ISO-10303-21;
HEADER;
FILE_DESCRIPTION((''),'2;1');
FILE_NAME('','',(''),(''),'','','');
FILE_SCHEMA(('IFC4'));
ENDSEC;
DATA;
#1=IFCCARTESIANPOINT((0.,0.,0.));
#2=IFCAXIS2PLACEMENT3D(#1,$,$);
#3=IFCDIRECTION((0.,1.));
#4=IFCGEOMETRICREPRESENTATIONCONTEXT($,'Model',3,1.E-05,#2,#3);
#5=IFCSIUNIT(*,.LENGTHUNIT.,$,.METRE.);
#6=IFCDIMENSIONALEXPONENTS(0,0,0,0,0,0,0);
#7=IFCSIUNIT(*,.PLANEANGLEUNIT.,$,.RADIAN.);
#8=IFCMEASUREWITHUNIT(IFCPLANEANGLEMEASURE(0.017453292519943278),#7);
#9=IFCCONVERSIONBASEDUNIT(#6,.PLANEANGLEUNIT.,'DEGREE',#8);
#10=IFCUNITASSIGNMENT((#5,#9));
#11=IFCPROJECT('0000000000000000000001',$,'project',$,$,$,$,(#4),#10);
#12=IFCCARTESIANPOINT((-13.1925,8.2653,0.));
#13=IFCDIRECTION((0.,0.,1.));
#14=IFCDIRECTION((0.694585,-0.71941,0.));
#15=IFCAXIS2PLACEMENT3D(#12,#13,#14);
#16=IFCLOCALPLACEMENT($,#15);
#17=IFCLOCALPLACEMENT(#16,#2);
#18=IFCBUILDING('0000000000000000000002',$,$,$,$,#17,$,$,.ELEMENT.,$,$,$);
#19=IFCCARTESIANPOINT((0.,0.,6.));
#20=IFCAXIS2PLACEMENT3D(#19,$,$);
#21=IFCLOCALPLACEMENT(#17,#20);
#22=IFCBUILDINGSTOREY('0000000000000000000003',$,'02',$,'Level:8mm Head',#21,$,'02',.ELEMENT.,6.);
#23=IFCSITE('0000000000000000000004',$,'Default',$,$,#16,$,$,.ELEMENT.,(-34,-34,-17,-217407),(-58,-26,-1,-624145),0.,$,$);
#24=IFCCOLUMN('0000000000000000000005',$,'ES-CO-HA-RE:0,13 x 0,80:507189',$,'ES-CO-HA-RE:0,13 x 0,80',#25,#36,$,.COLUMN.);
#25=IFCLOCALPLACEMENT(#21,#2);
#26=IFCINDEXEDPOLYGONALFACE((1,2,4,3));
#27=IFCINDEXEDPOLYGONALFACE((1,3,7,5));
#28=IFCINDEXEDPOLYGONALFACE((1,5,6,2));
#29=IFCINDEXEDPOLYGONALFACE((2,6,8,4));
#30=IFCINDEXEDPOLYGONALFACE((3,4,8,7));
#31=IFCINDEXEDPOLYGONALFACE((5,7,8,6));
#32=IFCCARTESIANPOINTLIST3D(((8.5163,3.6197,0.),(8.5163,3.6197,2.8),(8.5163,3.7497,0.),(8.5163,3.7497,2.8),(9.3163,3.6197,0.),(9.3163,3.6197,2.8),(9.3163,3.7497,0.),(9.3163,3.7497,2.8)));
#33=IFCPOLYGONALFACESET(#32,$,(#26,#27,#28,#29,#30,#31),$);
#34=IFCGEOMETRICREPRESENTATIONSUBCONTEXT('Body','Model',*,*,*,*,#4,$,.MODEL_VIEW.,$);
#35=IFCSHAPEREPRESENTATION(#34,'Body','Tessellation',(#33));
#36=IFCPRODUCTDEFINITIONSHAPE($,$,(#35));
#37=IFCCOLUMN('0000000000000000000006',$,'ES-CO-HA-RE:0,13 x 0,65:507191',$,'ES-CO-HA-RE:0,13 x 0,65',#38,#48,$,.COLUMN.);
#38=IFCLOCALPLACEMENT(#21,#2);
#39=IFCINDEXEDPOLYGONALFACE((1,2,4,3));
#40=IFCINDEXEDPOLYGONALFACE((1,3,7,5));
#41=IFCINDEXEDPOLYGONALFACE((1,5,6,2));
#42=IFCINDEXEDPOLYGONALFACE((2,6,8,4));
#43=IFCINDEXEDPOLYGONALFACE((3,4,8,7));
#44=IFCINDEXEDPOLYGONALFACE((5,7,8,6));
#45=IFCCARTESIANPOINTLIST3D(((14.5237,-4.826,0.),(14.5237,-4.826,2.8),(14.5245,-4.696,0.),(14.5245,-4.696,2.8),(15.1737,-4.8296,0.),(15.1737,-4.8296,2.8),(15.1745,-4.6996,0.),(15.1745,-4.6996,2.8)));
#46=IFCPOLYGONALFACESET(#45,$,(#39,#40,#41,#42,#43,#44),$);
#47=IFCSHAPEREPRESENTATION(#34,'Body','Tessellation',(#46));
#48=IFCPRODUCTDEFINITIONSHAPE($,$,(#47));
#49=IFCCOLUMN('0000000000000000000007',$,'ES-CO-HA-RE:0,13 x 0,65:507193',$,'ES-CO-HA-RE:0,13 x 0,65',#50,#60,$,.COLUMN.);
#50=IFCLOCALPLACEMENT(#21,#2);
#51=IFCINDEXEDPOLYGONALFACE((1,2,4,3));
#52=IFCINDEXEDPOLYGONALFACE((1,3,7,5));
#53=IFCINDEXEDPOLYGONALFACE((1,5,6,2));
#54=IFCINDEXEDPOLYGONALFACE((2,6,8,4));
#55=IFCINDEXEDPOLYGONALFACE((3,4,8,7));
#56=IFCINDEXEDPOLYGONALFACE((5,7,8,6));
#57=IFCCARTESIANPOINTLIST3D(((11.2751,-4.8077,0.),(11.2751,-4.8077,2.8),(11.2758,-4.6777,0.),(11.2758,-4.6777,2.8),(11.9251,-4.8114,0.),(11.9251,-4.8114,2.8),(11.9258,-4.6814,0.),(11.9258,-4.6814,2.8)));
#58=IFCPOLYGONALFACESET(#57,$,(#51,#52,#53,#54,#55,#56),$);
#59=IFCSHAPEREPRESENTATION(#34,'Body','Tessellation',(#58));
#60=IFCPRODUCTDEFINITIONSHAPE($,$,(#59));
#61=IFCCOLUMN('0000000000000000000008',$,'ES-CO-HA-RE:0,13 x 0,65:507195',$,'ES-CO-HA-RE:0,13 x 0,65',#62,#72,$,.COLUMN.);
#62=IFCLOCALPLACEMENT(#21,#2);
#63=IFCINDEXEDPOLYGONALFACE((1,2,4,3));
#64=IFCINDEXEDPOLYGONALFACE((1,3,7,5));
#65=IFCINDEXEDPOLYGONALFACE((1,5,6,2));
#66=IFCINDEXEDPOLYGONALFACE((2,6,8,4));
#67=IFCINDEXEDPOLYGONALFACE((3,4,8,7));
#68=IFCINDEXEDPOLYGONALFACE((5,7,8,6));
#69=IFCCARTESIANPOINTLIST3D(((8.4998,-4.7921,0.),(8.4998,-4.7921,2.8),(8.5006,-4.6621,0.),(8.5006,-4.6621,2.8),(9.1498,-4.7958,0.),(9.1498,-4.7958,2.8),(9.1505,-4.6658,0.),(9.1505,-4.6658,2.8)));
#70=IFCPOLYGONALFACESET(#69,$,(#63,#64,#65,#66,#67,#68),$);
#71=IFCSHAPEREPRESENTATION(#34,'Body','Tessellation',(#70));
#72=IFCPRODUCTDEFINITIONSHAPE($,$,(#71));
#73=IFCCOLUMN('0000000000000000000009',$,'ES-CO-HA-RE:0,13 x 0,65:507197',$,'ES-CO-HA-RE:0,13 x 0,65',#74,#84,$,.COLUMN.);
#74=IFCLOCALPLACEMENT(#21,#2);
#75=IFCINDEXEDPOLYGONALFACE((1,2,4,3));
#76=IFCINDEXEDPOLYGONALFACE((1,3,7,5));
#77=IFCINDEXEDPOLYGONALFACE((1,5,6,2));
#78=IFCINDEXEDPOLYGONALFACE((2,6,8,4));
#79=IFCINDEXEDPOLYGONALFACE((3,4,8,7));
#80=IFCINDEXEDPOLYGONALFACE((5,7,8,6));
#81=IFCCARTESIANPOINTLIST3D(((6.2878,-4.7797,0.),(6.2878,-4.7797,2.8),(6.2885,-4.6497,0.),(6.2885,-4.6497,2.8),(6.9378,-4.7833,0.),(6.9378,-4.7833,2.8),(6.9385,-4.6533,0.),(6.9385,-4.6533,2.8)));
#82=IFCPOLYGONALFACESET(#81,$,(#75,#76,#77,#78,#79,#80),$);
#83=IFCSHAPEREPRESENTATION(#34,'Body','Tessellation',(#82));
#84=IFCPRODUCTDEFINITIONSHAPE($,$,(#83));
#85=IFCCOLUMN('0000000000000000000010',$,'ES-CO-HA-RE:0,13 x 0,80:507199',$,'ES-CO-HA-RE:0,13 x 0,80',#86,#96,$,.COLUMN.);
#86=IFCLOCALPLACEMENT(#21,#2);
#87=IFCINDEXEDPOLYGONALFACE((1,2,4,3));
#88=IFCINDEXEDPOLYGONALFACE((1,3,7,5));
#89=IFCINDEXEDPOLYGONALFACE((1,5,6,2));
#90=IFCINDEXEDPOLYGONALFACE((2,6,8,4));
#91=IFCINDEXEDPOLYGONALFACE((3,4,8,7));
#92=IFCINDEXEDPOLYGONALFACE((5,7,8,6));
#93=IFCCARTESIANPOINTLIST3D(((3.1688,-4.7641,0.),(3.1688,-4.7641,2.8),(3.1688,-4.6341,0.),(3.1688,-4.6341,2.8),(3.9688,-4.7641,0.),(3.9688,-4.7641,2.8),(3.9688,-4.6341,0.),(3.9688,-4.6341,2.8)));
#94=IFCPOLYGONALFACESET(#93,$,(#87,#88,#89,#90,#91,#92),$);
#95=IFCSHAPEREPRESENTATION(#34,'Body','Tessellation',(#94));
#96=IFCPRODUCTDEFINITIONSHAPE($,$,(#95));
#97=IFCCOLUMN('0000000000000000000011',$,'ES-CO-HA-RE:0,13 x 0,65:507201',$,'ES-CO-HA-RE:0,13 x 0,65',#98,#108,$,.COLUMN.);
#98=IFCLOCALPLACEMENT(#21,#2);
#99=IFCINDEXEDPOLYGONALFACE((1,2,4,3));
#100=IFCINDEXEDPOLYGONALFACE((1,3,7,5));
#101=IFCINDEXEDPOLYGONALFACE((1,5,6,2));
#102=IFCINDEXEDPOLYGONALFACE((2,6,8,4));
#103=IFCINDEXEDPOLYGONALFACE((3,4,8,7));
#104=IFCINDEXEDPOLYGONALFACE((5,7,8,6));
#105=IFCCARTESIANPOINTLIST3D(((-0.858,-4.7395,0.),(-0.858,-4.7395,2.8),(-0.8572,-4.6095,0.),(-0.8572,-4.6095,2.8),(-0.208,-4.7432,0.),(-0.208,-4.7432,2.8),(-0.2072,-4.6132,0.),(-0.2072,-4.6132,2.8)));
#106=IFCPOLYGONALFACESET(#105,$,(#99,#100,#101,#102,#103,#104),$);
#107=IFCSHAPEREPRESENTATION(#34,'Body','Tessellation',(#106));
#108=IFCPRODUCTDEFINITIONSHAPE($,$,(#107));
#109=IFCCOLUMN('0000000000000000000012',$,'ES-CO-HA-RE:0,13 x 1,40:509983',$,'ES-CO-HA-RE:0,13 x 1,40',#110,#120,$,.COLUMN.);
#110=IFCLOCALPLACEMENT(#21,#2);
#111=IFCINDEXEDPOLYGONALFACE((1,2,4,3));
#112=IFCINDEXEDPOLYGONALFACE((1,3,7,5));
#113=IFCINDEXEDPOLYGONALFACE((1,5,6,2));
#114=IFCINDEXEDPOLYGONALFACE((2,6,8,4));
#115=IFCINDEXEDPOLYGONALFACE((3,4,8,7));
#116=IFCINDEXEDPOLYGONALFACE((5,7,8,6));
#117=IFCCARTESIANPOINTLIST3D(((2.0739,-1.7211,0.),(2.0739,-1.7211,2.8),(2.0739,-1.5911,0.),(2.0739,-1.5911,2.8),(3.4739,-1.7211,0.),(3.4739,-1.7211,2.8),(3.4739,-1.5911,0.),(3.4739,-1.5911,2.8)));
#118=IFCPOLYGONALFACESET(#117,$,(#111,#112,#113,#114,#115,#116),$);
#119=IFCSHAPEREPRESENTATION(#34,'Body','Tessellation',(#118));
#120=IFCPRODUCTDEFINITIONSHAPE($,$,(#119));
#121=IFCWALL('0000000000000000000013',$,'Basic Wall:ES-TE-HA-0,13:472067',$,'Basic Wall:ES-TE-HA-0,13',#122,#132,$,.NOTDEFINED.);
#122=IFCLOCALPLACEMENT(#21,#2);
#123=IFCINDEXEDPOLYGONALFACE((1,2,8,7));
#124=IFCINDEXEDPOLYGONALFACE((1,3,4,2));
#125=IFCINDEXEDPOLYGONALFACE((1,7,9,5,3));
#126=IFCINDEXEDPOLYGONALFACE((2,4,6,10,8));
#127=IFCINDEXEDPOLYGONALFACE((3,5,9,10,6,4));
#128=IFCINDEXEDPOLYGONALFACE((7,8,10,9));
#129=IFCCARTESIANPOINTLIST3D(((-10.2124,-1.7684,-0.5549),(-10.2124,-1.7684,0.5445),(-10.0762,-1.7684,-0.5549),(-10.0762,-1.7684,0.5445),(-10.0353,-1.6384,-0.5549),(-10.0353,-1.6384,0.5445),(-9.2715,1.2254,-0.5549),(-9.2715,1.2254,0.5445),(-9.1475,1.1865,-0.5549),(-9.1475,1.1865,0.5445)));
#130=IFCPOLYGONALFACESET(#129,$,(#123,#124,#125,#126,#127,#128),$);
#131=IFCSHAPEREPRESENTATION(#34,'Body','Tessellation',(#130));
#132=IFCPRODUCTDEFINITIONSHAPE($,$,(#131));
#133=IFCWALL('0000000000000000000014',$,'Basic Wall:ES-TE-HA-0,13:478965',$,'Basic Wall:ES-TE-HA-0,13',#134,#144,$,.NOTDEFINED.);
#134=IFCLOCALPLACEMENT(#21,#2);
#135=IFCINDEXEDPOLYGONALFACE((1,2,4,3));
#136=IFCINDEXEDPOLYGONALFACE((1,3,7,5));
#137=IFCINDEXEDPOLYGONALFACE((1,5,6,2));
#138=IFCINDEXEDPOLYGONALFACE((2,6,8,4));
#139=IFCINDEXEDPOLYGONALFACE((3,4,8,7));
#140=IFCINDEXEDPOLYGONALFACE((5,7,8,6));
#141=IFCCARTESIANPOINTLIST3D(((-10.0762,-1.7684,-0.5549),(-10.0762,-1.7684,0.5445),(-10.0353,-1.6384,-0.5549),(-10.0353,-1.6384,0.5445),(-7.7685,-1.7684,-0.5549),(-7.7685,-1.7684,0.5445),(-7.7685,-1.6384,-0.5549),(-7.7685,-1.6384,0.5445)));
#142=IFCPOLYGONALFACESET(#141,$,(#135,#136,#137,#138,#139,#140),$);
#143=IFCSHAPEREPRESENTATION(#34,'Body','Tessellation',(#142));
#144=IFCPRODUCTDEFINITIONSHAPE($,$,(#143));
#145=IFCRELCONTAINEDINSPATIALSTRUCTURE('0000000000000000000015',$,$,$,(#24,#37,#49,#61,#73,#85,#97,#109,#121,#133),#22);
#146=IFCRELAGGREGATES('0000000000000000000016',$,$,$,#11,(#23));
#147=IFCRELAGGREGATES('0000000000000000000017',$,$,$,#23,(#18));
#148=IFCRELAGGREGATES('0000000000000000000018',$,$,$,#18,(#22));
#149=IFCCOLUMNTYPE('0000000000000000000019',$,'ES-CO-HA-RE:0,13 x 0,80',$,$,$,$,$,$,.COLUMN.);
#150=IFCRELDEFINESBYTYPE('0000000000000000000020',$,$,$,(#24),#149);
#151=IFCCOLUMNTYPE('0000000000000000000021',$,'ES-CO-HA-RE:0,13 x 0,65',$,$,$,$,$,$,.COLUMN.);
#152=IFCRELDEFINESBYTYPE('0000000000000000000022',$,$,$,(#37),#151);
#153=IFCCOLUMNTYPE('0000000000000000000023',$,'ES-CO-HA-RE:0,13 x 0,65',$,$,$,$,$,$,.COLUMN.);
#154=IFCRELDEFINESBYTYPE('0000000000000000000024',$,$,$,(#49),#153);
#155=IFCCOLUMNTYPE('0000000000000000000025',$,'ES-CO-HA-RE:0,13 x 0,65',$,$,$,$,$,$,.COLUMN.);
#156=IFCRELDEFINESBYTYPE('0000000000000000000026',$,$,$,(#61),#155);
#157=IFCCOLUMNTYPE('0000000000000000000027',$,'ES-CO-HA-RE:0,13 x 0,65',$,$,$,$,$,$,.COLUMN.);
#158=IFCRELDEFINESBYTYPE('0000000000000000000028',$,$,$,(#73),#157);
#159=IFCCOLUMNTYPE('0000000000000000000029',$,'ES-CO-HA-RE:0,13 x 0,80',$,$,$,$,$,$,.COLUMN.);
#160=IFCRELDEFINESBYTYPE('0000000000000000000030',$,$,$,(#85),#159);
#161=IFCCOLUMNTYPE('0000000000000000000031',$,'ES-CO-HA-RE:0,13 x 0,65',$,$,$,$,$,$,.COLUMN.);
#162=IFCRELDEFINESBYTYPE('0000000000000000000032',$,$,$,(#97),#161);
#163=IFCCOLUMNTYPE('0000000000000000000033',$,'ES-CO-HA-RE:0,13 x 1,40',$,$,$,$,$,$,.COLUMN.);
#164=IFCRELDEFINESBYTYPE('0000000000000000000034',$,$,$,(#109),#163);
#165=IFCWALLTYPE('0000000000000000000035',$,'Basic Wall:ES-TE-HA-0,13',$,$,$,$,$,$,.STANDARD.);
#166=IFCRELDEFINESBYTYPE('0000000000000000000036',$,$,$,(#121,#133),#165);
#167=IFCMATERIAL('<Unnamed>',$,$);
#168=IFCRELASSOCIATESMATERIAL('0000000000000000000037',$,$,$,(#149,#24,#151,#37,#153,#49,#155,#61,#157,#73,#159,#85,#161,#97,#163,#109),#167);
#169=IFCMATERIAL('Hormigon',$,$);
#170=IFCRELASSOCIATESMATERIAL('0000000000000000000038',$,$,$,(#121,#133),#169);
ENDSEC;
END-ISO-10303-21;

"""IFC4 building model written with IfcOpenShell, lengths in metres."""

from ifc_helpers import new_model, entity, si_unit, converted_unit, direction, frame, origin, place, context, subcontext, project, spatial, indexed_curve, outline, extrude, source, transform, mapped, material, type_object, type_shapes, element, save


model = new_model("IFC4")

# Units and contexts
model_context = context("Model", 3, precision=1e-05, world=origin(), true_north=direction((0.0, 1.0)))
body_context = subcontext(model_context, "Body", "Model", "MODEL_VIEW")
ifc_project = project(units=[si_unit("LENGTHUNIT", "METRE"), converted_unit("PLANEANGLEUNIT", "DEGREE", entity("IfcPlaneAngleMeasure", 0.017453292519943278), si_unit("PLANEANGLEUNIT", "RADIAN"), dimensions=[0, 0, 0, 0, 0, 0, 0])], contexts=[model_context])

# Site, building, storey
site_placement = place(None, frame((-13.1925, 8.2653, 0.0), z_axis=(0.0, 0.0, 1.0), x_axis=(0.694585, -0.71941, 0.0)))
site = spatial("IfcSite", under=ifc_project, at=site_placement, Name="Default", CompositionType="ELEMENT", RefLatitude=(-34, -34, -17, -217407), RefLongitude=(-58, -26, -1, -624145), RefElevation=0.0)
building_placement = place(site_placement, origin())
building = spatial("IfcBuilding", under=site, at=building_placement, CompositionType="ELEMENT")
storey_placement = place(building_placement, frame((0.0, 0.0, 6.0)))
storey = spatial("IfcBuildingStorey", under=building, at=storey_placement, Name="02", ObjectType="Level:8mm Head", LongName="02", CompositionType="ELEMENT", Elevation=6.0)

# Columns
ifc_material_1 = material(Name="<Unnamed>")
ifc_material_2 = material(Name="Hormigon")
column_type_1 = type_object("IfcColumnType", Name="ES-CO-HA-RE:0,13 x 0,80", PredefinedType="COLUMN", material=ifc_material_1)
shared_shape_1 = source(origin(), body_context, "Body", "SweptSolid", [
    extrude(outline(indexed_curve([(-0.4, -0.065), (0.4, -0.065), (0.4, 0.065), (-0.4, 0.065), (-0.4, -0.065)], self_intersect=False)), frame((8.9163, 3.6847, 6.0), z_axis=(0.0, 0.0, 1.0), x_axis=(-1.0, 0.0, 0.0)), (0.0, 0.0, 1.0), 2.8),
])
type_shapes(column_type_1, [shared_shape_1])
column_1_placement = place(storey_placement, frame((0.0, 0.0, -6.0)))
element("IfcColumn", 1, at=column_1_placement, inside=storey, type_object=column_type_1, material=ifc_material_1, Name="ES-CO-HA-RE:0,13 x 0,80:507189", ObjectType="ES-CO-HA-RE:0,13 x 0,80", PredefinedType="COLUMN", context=body_context, shape_type="MappedRepresentation", body=[
    mapped(shared_shape_1, transform((0.0, 0.0, 0.0), scale=1.0)),
])
column_type_2 = type_object("IfcColumnType", Name="ES-CO-HA-RE:0,13 x 0,65", PredefinedType="COLUMN", material=ifc_material_1)
shared_shape_2 = source(origin(), body_context, "Body", "SweptSolid", [
    extrude(outline(indexed_curve([(-0.325, -0.065), (0.325, -0.065), (0.325, 0.065), (-0.325, 0.065), (-0.325, -0.065)], self_intersect=False)), frame((14.8491, -4.7628, 6.0), z_axis=(0.0, 0.0, 1.0), x_axis=(-0.999984, 0.005619, 0.0)), (0.0, 0.0, 1.0), 2.8),
])
type_shapes(column_type_2, [shared_shape_2])
column_2_placement = place(storey_placement, frame((0.0, 0.0, -6.0)))
element("IfcColumn", 2, at=column_2_placement, inside=storey, type_object=column_type_2, material=ifc_material_1, Name="ES-CO-HA-RE:0,13 x 0,65:507191", ObjectType="ES-CO-HA-RE:0,13 x 0,65", PredefinedType="COLUMN", context=body_context, shape_type="MappedRepresentation", body=[
    mapped(shared_shape_2, transform((0.0, 0.0, 0.0), scale=1.0)),
])
column_type_3 = type_object("IfcColumnType", Name="ES-CO-HA-RE:0,13 x 0,65", PredefinedType="COLUMN", material=ifc_material_1)
shared_shape_3 = source(origin(), body_context, "Body", "SweptSolid", [
    extrude(outline(indexed_curve([(-0.325, -0.065), (0.325, -0.065), (0.325, 0.065), (-0.325, 0.065), (-0.325, -0.065)], self_intersect=False)), frame((11.6005, -4.7445, 6.0), z_axis=(0.0, 0.0, 1.0), x_axis=(-0.999984, 0.005619, 0.0)), (0.0, 0.0, 1.0), 2.8),
])
type_shapes(column_type_3, [shared_shape_3])
column_3_placement = place(storey_placement, frame((0.0, 0.0, -6.0)))
element("IfcColumn", 3, at=column_3_placement, inside=storey, type_object=column_type_3, material=ifc_material_1, Name="ES-CO-HA-RE:0,13 x 0,65:507193", ObjectType="ES-CO-HA-RE:0,13 x 0,65", PredefinedType="COLUMN", context=body_context, shape_type="MappedRepresentation", body=[
    mapped(shared_shape_3, transform((0.0, 0.0, 0.0), scale=1.0)),
])
column_type_4 = type_object("IfcColumnType", Name="ES-CO-HA-RE:0,13 x 0,65", PredefinedType="COLUMN", material=ifc_material_1)
shared_shape_4 = source(origin(), body_context, "Body", "SweptSolid", [
    extrude(outline(indexed_curve([(-0.325, -0.065), (0.325, -0.065), (0.325, 0.065), (-0.325, 0.065), (-0.325, -0.065)], self_intersect=False)), frame((8.8252, -4.7289, 6.0), z_axis=(0.0, 0.0, 1.0), x_axis=(-0.999984, 0.005619, 0.0)), (0.0, 0.0, 1.0), 2.8),
])
type_shapes(column_type_4, [shared_shape_4])
column_4_placement = place(storey_placement, frame((0.0, 0.0, -6.0)))
element("IfcColumn", 4, at=column_4_placement, inside=storey, type_object=column_type_4, material=ifc_material_1, Name="ES-CO-HA-RE:0,13 x 0,65:507195", ObjectType="ES-CO-HA-RE:0,13 x 0,65", PredefinedType="COLUMN", context=body_context, shape_type="MappedRepresentation", body=[
    mapped(shared_shape_4, transform((0.0, 0.0, 0.0), scale=1.0)),
])
column_type_5 = type_object("IfcColumnType", Name="ES-CO-HA-RE:0,13 x 0,65", PredefinedType="COLUMN", material=ifc_material_1)
shared_shape_5 = source(origin(), body_context, "Body", "SweptSolid", [
    extrude(outline(indexed_curve([(-0.325, -0.065), (0.325, -0.065), (0.325, 0.065), (-0.325, 0.065), (-0.325, -0.065)], self_intersect=False)), frame((6.6131, -4.7165, 6.0), z_axis=(0.0, 0.0, 1.0), x_axis=(-0.999984, 0.005619, 0.0)), (0.0, 0.0, 1.0), 2.8),
])
type_shapes(column_type_5, [shared_shape_5])
column_5_placement = place(storey_placement, frame((0.0, 0.0, -6.0)))
element("IfcColumn", 5, at=column_5_placement, inside=storey, type_object=column_type_5, material=ifc_material_1, Name="ES-CO-HA-RE:0,13 x 0,65:507197", ObjectType="ES-CO-HA-RE:0,13 x 0,65", PredefinedType="COLUMN", context=body_context, shape_type="MappedRepresentation", body=[
    mapped(shared_shape_5, transform((0.0, 0.0, 0.0), scale=1.0)),
])
column_type_6 = type_object("IfcColumnType", Name="ES-CO-HA-RE:0,13 x 0,80", PredefinedType="COLUMN", material=ifc_material_1)
shared_shape_6 = source(origin(), body_context, "Body", "SweptSolid", [
    extrude(outline(indexed_curve([(-0.4, -0.065), (0.4, -0.065), (0.4, 0.065), (-0.4, 0.065), (-0.4, -0.065)], self_intersect=False)), frame((3.5688, -4.6991, 6.0), z_axis=(0.0, 0.0, 1.0), x_axis=(-1.0, 0.0, 0.0)), (0.0, 0.0, 1.0), 2.8),
])
type_shapes(column_type_6, [shared_shape_6])
column_6_placement = place(storey_placement, frame((0.0, 0.0, -6.0)))
element("IfcColumn", 6, at=column_6_placement, inside=storey, type_object=column_type_6, material=ifc_material_1, Name="ES-CO-HA-RE:0,13 x 0,80:507199", ObjectType="ES-CO-HA-RE:0,13 x 0,80", PredefinedType="COLUMN", context=body_context, shape_type="MappedRepresentation", body=[
    mapped(shared_shape_6, transform((0.0, 0.0, 0.0), scale=1.0)),
])
column_type_7 = type_object("IfcColumnType", Name="ES-CO-HA-RE:0,13 x 0,65", PredefinedType="COLUMN", material=ifc_material_1)
shared_shape_7 = source(origin(), body_context, "Body", "SweptSolid", [
    extrude(outline(indexed_curve([(-0.325, -0.065), (0.325, -0.065), (0.325, 0.065), (-0.325, 0.065), (-0.325, -0.065)], self_intersect=False)), frame((-0.5326, -4.6764, 6.0), z_axis=(0.0, 0.0, 1.0), x_axis=(-0.999984, 0.005619, 0.0)), (0.0, 0.0, 1.0), 2.8),
])
type_shapes(column_type_7, [shared_shape_7])
column_7_placement = place(storey_placement, frame((0.0, 0.0, -6.0)))
element("IfcColumn", 7, at=column_7_placement, inside=storey, type_object=column_type_7, material=ifc_material_1, Name="ES-CO-HA-RE:0,13 x 0,65:507201", ObjectType="ES-CO-HA-RE:0,13 x 0,65", PredefinedType="COLUMN", context=body_context, shape_type="MappedRepresentation", body=[
    mapped(shared_shape_7, transform((0.0, 0.0, 0.0), scale=1.0)),
])
column_type_8 = type_object("IfcColumnType", Name="ES-CO-HA-RE:0,13 x 1,40", PredefinedType="COLUMN", material=ifc_material_1)
shared_shape_8 = source(origin(), body_context, "Body", "SweptSolid", [
    extrude(outline(indexed_curve([(-0.7, -0.065), (0.7, -0.065), (0.7, 0.065), (-0.7, 0.065), (-0.7, -0.065)], self_intersect=False)), frame((2.7739, -1.6561, 6.0), z_axis=(0.0, 0.0, 1.0), x_axis=(-1.0, 0.0, 0.0)), (0.0, 0.0, 1.0), 2.8),
])
type_shapes(column_type_8, [shared_shape_8])
column_8_placement = place(storey_placement, frame((0.0, 0.0, -6.0)))
element("IfcColumn", 8, at=column_8_placement, inside=storey, type_object=column_type_8, material=ifc_material_1, Name="ES-CO-HA-RE:0,13 x 1,40:509983", ObjectType="ES-CO-HA-RE:0,13 x 1,40", PredefinedType="COLUMN", context=body_context, shape_type="MappedRepresentation", body=[
    mapped(shared_shape_8, transform((0.0, 0.0, 0.0), scale=1.0)),
])

# Walls
wall_type = type_object("IfcWallType", Name="Basic Wall:ES-TE-HA-0,13", PredefinedType="STANDARD")
wall_1_placement = place(storey_placement, frame((-10.1504, -1.7879, -0.5549), z_axis=(0.0, 0.0, 1.0), x_axis=(0.299835, 0.953991, 0.0)))
element("IfcWall", 9, at=wall_1_placement, inside=storey, type_object=wall_type, material=ifc_material_2, Name="Basic Wall:ES-TE-HA-0,13:472067", ObjectType="Basic Wall:ES-TE-HA-0,13", PredefinedType="NOTDEFINED", context=body_context, shape_type="SweptSolid", body=[
    extrude(outline(indexed_curve([(3.1382, -0.065), (3.1382, 0.065), (0.0, 0.065), (0.0409, -0.065), (0.1771, -0.065), (3.1382, -0.065)], self_intersect=False)), origin(), (0.0, 0.0, 1.0), 1.0993),
])
wall_2_placement = place(storey_placement, frame((-10.0762, -1.7034, -0.5549)))
element("IfcWall", 10, at=wall_2_placement, inside=storey, type_object=wall_type, material=ifc_material_2, Name="Basic Wall:ES-TE-HA-0,13:478965", ObjectType="Basic Wall:ES-TE-HA-0,13", PredefinedType="NOTDEFINED", context=body_context, shape_type="SweptSolid", body=[
    extrude(outline(indexed_curve([(2.3077, -0.065), (2.3077, 0.065), (0.0409, 0.065), (0.0, -0.065), (2.3077, -0.065)], self_intersect=False)), origin(), (0.0, 0.0, 1.0), 1.0993),
])

save(model, "model.ifc")
